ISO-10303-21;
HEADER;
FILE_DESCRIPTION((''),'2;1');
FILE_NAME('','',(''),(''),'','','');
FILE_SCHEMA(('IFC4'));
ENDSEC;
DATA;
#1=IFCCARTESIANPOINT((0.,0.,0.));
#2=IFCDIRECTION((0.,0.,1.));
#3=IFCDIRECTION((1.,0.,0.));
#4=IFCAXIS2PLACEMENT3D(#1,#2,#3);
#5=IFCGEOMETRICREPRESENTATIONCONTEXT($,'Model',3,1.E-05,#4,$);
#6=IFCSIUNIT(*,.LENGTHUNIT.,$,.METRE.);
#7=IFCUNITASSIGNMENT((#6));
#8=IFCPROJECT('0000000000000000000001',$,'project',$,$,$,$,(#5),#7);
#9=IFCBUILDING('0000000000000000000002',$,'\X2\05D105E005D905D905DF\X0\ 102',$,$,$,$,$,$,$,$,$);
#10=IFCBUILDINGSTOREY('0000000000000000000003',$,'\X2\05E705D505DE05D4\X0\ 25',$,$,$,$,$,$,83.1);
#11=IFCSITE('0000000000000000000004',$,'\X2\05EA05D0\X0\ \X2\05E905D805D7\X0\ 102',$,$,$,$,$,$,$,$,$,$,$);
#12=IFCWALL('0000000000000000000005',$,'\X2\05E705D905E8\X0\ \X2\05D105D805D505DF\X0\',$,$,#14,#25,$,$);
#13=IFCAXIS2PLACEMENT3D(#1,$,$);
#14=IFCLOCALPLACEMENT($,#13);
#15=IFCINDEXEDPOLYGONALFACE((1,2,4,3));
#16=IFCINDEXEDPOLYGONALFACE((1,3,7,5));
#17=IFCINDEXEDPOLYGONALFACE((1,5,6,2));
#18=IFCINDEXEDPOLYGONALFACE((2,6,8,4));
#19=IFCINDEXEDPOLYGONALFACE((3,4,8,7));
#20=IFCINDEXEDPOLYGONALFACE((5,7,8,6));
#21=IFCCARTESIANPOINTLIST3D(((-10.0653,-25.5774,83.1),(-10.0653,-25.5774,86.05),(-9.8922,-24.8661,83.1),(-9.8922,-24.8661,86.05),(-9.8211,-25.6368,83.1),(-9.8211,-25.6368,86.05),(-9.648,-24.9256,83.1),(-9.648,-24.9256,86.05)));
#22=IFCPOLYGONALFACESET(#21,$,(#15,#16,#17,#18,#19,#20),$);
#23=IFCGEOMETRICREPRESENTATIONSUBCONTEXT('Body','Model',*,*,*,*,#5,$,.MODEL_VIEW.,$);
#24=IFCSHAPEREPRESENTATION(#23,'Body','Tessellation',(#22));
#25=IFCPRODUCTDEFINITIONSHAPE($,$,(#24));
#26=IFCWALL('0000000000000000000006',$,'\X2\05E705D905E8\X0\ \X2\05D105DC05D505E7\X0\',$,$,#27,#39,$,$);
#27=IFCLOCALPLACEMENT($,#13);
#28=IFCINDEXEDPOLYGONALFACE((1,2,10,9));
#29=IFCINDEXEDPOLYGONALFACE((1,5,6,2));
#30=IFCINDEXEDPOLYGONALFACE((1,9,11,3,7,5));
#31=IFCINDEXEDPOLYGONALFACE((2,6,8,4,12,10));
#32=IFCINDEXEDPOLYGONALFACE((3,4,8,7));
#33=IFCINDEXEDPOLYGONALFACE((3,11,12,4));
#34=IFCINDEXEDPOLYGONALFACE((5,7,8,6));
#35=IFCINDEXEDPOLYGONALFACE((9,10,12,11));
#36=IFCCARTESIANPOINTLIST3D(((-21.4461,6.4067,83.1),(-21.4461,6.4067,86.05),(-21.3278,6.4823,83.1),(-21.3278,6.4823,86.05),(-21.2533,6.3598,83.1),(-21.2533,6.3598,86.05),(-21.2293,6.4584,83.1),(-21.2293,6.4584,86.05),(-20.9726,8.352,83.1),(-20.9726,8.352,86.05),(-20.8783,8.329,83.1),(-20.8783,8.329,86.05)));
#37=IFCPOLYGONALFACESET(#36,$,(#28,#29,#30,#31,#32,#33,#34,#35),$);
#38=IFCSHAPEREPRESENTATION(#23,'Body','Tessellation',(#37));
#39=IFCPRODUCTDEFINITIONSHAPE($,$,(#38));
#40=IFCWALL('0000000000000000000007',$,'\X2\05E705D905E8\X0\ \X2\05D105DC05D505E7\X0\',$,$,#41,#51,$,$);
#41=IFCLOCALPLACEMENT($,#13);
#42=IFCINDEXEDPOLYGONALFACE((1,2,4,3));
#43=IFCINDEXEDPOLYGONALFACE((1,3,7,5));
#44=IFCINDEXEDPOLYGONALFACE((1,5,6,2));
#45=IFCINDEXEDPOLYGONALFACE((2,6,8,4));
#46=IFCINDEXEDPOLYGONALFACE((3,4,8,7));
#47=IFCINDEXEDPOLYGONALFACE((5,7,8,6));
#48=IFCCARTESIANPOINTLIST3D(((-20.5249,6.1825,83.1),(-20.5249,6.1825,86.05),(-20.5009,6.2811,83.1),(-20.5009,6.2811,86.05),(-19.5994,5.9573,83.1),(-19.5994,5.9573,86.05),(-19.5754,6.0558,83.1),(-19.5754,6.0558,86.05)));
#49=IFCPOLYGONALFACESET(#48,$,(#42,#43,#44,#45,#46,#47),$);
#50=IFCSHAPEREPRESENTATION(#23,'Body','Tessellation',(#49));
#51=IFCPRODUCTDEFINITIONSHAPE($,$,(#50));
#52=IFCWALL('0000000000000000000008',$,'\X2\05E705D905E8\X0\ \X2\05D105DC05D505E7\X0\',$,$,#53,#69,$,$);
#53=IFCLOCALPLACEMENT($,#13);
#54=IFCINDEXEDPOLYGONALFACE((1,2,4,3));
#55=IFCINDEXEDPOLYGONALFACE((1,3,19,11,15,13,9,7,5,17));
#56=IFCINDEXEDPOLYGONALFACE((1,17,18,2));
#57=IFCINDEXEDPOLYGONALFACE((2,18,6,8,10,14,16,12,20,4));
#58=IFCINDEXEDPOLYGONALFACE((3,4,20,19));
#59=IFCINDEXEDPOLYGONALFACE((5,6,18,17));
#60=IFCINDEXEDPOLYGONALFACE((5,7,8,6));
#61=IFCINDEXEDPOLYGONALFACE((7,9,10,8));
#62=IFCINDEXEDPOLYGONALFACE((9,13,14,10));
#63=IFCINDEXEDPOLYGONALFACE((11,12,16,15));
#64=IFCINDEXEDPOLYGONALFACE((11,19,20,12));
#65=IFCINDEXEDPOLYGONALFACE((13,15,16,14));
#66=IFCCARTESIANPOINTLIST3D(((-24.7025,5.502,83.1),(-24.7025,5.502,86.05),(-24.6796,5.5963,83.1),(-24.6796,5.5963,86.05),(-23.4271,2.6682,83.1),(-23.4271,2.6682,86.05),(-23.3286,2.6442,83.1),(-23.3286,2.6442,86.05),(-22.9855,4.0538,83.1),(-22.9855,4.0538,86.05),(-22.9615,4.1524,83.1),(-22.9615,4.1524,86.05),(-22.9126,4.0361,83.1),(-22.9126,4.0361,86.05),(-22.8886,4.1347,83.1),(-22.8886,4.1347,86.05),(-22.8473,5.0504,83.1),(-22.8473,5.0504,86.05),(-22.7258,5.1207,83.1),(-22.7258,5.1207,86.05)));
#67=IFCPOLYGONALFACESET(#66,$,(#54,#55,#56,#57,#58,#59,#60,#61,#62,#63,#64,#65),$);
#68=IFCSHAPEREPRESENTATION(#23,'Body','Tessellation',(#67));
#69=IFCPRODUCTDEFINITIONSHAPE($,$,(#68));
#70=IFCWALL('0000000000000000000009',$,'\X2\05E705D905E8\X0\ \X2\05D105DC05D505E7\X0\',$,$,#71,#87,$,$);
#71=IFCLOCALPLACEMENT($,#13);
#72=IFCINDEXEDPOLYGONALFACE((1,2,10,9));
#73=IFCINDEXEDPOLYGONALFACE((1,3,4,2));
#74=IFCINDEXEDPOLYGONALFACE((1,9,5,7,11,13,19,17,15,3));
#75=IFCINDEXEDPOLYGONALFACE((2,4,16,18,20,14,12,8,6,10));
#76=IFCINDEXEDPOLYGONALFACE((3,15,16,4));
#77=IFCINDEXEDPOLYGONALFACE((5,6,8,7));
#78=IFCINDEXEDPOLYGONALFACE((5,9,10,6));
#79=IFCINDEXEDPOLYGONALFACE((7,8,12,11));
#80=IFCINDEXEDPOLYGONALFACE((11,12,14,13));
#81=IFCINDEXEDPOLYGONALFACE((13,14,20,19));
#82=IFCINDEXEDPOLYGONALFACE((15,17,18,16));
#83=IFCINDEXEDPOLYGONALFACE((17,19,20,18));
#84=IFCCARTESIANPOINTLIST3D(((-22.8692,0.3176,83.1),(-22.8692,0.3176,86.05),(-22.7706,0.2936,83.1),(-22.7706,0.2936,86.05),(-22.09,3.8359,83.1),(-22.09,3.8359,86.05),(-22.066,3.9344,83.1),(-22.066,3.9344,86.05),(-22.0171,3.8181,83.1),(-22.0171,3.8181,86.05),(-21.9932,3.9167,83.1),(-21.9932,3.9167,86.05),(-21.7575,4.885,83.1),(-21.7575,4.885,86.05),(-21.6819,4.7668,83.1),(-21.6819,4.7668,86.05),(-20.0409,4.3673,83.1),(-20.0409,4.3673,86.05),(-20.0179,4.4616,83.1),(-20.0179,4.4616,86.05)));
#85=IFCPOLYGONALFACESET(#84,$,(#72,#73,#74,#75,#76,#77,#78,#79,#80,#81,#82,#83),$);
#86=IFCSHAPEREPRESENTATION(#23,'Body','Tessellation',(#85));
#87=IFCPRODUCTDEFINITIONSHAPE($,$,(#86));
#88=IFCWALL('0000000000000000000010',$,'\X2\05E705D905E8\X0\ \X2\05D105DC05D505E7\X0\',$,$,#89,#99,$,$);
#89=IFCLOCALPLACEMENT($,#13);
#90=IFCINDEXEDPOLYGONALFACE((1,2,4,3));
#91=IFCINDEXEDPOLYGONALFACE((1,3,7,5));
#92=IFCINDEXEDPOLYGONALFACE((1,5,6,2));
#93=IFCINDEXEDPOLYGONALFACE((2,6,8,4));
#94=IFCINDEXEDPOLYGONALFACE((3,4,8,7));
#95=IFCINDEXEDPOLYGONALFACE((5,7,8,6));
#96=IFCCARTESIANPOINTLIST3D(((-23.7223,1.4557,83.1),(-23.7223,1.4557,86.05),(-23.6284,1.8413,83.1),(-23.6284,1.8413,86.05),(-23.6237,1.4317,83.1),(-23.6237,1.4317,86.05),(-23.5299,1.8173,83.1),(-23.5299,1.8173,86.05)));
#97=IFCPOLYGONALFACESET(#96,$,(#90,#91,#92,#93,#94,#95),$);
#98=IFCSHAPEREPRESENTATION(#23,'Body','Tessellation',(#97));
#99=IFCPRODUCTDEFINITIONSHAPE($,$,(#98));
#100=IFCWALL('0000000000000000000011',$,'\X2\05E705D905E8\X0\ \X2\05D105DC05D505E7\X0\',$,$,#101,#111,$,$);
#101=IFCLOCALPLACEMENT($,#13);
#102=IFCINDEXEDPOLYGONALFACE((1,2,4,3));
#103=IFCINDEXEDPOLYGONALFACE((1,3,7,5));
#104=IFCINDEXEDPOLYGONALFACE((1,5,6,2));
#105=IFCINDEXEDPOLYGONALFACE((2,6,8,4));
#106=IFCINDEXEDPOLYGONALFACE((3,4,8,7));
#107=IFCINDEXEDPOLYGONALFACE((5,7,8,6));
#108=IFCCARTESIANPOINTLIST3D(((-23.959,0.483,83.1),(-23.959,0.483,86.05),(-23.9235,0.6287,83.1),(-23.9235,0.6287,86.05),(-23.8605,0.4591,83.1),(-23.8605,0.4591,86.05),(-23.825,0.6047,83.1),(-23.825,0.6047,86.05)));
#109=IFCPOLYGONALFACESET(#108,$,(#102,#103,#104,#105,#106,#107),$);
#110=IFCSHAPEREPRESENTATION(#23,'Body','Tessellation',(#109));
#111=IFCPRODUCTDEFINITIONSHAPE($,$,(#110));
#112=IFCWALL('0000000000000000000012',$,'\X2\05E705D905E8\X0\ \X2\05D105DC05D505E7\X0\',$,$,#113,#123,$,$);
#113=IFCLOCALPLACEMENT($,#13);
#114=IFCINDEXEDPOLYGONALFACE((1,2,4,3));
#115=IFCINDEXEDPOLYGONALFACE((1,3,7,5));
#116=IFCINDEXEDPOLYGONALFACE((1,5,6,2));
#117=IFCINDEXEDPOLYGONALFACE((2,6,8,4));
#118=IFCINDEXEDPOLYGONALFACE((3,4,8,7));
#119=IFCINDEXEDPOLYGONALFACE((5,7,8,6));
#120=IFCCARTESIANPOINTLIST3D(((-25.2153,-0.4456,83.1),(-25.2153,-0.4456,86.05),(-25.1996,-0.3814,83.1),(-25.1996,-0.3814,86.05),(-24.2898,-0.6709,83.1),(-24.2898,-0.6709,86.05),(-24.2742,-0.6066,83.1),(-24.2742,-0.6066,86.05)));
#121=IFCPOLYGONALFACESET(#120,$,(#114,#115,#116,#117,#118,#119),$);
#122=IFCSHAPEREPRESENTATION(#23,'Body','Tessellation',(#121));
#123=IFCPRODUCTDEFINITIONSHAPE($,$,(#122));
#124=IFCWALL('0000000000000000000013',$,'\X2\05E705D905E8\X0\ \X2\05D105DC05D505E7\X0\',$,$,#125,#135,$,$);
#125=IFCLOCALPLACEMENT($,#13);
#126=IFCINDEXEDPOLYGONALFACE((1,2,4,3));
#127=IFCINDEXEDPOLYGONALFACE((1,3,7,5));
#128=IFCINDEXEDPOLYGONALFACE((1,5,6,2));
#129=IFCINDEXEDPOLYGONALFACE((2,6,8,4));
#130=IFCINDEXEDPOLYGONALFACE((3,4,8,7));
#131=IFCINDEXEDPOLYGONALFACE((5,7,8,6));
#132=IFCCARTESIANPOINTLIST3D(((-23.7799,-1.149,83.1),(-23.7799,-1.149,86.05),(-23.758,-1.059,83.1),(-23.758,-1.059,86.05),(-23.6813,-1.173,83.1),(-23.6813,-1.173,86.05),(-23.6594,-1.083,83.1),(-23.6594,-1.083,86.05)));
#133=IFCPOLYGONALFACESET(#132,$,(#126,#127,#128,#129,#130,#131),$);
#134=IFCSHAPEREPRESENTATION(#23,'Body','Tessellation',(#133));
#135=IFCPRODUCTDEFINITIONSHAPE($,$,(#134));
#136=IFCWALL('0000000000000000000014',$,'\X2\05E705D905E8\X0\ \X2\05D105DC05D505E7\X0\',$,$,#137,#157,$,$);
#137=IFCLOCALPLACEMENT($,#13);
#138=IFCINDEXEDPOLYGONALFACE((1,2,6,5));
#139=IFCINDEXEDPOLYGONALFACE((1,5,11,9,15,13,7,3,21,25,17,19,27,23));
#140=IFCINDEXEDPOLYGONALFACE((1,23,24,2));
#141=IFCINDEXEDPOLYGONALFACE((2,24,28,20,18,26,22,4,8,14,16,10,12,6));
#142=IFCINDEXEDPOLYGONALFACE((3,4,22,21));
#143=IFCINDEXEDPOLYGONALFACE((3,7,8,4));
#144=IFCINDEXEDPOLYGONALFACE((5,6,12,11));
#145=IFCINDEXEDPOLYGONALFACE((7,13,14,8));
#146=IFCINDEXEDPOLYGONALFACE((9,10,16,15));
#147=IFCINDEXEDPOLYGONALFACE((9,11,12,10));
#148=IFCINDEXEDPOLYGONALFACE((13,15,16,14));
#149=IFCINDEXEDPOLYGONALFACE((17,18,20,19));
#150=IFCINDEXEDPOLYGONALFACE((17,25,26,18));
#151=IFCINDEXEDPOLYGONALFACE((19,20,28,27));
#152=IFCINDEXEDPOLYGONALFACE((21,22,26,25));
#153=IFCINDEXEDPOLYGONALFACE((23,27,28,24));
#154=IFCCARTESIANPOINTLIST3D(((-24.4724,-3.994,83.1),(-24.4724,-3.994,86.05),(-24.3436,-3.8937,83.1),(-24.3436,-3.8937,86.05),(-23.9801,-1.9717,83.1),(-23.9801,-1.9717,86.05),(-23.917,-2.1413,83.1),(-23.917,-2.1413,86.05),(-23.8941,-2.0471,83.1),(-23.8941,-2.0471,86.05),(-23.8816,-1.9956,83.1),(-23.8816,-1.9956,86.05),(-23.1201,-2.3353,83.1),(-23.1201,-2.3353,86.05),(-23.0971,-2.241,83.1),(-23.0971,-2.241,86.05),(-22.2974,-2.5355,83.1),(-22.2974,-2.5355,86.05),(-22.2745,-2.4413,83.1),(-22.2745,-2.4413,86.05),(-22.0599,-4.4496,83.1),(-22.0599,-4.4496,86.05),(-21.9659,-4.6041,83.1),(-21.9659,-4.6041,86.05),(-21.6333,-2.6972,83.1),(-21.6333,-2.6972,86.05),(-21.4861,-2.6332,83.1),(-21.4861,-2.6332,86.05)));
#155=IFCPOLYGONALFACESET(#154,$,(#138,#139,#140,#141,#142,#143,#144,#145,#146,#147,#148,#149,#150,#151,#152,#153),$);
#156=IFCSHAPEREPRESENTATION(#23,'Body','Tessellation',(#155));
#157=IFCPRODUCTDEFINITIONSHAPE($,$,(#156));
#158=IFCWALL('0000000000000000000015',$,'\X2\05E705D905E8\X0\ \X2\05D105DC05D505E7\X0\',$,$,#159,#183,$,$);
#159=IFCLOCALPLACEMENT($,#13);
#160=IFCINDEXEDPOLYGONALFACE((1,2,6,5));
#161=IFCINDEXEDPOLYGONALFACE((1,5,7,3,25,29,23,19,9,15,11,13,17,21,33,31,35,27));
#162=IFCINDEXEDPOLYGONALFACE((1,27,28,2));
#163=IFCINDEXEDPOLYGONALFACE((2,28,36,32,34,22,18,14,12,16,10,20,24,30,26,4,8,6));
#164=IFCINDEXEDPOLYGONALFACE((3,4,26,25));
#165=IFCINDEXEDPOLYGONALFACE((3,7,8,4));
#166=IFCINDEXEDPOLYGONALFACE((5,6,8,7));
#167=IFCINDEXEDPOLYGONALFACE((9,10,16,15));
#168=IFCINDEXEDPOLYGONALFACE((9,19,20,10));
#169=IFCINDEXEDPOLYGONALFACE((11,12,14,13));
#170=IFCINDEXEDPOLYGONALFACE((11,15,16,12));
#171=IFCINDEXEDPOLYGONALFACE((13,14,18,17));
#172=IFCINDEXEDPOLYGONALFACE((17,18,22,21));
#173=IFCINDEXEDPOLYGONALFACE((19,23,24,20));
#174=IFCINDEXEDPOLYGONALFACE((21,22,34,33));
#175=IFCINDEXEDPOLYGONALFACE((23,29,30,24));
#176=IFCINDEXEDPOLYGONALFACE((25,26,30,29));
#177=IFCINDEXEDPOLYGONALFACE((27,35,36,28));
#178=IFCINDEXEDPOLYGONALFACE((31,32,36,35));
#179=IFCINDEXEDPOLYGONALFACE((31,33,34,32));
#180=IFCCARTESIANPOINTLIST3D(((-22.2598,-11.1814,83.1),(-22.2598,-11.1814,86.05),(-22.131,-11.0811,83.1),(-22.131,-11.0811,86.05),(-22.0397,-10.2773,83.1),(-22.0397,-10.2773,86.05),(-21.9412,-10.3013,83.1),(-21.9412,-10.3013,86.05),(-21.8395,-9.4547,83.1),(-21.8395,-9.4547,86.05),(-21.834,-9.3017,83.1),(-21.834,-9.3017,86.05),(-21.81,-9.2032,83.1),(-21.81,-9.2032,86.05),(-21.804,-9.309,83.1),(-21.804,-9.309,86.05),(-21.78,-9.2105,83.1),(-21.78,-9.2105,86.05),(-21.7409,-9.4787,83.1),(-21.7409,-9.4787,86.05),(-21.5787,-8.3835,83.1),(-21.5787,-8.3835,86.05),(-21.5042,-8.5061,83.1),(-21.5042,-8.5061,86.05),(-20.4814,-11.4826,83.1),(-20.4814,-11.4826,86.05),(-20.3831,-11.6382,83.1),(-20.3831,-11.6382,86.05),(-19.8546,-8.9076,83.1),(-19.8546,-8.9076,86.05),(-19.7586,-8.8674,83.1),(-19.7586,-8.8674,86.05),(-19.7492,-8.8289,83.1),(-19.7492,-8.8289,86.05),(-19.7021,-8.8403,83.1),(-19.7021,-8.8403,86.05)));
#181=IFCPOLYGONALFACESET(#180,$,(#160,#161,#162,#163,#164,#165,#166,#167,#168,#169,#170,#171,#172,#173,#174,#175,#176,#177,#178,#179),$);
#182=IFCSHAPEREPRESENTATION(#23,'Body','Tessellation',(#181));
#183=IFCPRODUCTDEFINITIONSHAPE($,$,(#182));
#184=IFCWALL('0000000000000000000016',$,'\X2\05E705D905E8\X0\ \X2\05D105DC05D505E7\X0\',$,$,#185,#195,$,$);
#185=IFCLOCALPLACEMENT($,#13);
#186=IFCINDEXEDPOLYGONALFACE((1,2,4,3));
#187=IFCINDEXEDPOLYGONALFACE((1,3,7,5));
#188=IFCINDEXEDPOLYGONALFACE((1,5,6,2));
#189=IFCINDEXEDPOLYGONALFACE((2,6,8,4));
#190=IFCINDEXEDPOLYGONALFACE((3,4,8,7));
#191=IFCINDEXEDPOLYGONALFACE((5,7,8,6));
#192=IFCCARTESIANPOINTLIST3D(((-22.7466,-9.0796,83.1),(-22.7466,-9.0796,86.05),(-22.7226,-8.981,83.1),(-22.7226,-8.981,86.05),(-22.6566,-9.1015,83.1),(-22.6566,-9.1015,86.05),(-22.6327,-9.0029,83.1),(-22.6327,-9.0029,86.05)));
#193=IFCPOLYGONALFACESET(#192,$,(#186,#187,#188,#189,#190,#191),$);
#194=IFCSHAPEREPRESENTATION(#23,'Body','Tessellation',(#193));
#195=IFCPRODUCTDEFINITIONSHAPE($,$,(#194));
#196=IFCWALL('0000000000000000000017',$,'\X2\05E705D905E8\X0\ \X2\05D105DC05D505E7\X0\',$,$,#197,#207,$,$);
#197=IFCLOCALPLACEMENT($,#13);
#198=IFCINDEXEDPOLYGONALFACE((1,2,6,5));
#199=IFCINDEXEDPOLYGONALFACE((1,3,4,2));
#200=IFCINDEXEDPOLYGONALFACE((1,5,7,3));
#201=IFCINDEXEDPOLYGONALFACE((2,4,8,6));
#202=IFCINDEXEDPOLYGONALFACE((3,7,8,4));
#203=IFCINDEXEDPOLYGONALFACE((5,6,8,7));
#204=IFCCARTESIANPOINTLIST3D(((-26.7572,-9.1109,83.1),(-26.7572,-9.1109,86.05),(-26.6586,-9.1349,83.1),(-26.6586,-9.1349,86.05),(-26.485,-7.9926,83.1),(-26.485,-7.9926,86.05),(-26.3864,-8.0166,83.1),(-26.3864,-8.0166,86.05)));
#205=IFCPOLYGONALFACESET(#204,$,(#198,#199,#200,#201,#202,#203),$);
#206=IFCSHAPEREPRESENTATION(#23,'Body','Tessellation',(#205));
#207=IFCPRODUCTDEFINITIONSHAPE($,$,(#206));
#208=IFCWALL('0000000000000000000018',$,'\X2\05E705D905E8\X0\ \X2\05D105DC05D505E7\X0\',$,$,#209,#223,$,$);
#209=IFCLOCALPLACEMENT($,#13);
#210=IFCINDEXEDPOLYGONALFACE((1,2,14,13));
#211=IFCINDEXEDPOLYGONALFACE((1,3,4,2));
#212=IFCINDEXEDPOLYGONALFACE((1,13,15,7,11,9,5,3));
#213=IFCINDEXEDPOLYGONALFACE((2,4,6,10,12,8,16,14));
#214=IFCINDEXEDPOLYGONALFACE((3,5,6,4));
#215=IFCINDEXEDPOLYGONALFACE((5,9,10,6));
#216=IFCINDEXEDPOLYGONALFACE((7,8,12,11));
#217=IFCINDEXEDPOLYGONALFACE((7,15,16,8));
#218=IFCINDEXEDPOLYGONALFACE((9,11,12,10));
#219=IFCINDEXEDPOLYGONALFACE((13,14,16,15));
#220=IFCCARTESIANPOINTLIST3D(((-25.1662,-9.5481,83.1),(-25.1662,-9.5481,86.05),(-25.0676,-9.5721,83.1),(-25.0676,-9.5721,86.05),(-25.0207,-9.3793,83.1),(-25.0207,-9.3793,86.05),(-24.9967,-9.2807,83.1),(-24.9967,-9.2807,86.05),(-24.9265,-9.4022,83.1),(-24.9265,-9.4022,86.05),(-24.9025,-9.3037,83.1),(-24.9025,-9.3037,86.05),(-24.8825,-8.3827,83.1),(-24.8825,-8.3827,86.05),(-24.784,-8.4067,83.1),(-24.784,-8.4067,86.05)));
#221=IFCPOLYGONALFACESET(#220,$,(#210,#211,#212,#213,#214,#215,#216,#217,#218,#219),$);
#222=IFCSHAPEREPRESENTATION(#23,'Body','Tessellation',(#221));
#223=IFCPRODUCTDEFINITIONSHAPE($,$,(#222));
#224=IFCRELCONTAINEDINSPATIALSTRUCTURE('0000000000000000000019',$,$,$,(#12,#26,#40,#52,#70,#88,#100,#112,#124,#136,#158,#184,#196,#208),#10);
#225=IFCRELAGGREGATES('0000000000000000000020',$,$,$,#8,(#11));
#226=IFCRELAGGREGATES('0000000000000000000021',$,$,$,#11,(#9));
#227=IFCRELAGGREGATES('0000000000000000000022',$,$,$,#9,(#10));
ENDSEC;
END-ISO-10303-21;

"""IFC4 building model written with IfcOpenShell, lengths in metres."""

from ifc_helpers import new_model, si_unit, frame, origin_with_axes, context, subcontext, project, spatial, polyline, outline, extrude, element, save


model = new_model("IFC4")

# Units and contexts
model_context = context("Model", 3, precision=1e-05, world=origin_with_axes())
body_context = subcontext(model_context, "Body", "Model", "MODEL_VIEW")
ifc_project = project(units=[si_unit("LENGTHUNIT", "METRE")], contexts=[model_context])

# Site, building, storey
site = spatial("IfcSite", under=ifc_project, Name="תא שטח 102")
building = spatial("IfcBuilding", under=site, Name="בניין 102")
storey = spatial("IfcBuildingStorey", under=building, Name="קומה 25", Elevation=83.1)

# Walls
element("IfcWall", 1, inside=storey, Name="קיר בטון", context=body_context, shape_type="SweptSolid", body=[
    extrude(outline(polyline([(-10.0653, -25.5774), (-9.8211, -25.6368), (-9.648, -24.9256), (-9.8922, -24.8661), (-10.0653, -25.5774)])), frame((0.0, 0.0, 83.1)), (0.0, 0.0, 1.0), 2.95),
])
element("IfcWall", 2, inside=storey, Name="קיר בלוק", context=body_context, shape_type="SweptSolid", body=[
    extrude(outline(polyline([(-21.4461, 6.4067), (-21.2533, 6.3598), (-21.2293, 6.4584), (-21.3278, 6.4823), (-20.8783, 8.329), (-20.9726, 8.352), (-21.4461, 6.4067)])), frame((0.0, 0.0, 83.1)), (0.0, 0.0, 1.0), 2.95),
])
element("IfcWall", 3, inside=storey, Name="קיר בלוק", context=body_context, shape_type="SweptSolid", body=[
    extrude(outline(polyline([(-19.5754, 6.0558), (-20.5009, 6.2811), (-20.5249, 6.1825), (-19.5994, 5.9573), (-19.5754, 6.0558)])), frame((0.0, 0.0, 83.1)), (0.0, 0.0, 1.0), 2.95),
])
element("IfcWall", 4, inside=storey, Name="קיר בלוק", context=body_context, shape_type="SweptSolid", body=[
    extrude(outline(polyline([(-23.4271, 2.6682), (-23.3286, 2.6442), (-22.9855, 4.0538), (-22.9126, 4.0361), (-22.8886, 4.1347), (-22.9615, 4.1524), (-22.7258, 5.1207), (-24.6796, 5.5963), (-24.7025, 5.502), (-22.8473, 5.0504), (-23.4271, 2.6682)])), frame((0.0, 0.0, 83.1)), (0.0, 0.0, 1.0), 2.95),
])
element("IfcWall", 5, inside=storey, Name="קיר בלוק", context=body_context, shape_type="SweptSolid", body=[
    extrude(outline(polyline([(-22.09, 3.8359), (-22.0171, 3.8181), (-22.8692, 0.3176), (-22.7706, 0.2936), (-21.6819, 4.7668), (-20.0409, 4.3673), (-20.0179, 4.4616), (-21.7575, 4.885), (-21.9932, 3.9167), (-22.066, 3.9344), (-22.09, 3.8359)])), frame((0.0, 0.0, 83.1)), (0.0, 0.0, 1.0), 2.95),
])
element("IfcWall", 6, inside=storey, Name="קיר בלוק", context=body_context, shape_type="SweptSolid", body=[
    extrude(outline(polyline([(-23.5299, 1.8173), (-23.6284, 1.8413), (-23.7223, 1.4557), (-23.6237, 1.4317), (-23.5299, 1.8173)])), frame((0.0, 0.0, 83.1)), (0.0, 0.0, 1.0), 2.95),
])
element("IfcWall", 7, inside=storey, Name="קיר בלוק", context=body_context, shape_type="SweptSolid", body=[
    extrude(outline(polyline([(-23.9235, 0.6287), (-23.959, 0.483), (-23.8605, 0.4591), (-23.825, 0.6047), (-23.9235, 0.6287)])), frame((0.0, 0.0, 83.1)), (0.0, 0.0, 1.0), 2.95),
])
element("IfcWall", 8, inside=storey, Name="קיר בלוק", context=body_context, shape_type="SweptSolid", body=[
    extrude(outline(polyline([(-25.1996, -0.3814), (-25.2153, -0.4456), (-24.2898, -0.6709), (-24.2742, -0.6066), (-25.1996, -0.3814)])), frame((0.0, 0.0, 83.1)), (0.0, 0.0, 1.0), 2.95),
])
element("IfcWall", 9, inside=storey, Name="קיר בלוק", context=body_context, shape_type="SweptSolid", body=[
    extrude(outline(polyline([(-23.6594, -1.083), (-23.758, -1.059), (-23.7799, -1.149), (-23.6813, -1.173), (-23.6594, -1.083)])), frame((0.0, 0.0, 83.1)), (0.0, 0.0, 1.0), 2.95),
])
element("IfcWall", 10, inside=storey, Name="קיר בלוק", context=body_context, shape_type="SweptSolid", body=[
    extrude(outline(polyline([(-24.3436, -3.8937), (-23.917, -2.1413), (-23.1201, -2.3353), (-23.0971, -2.241), (-23.8941, -2.0471), (-23.8816, -1.9956), (-23.9801, -1.9717), (-24.4724, -3.994), (-21.9659, -4.6041), (-21.4861, -2.6332), (-22.2745, -2.4413), (-22.2974, -2.5355), (-21.6333, -2.6972), (-22.0599, -4.4496), (-24.3436, -3.8937)])), frame((0.0, 0.0, 83.1)), (0.0, 0.0, 1.0), 2.95),
])
element("IfcWall", 11, inside=storey, Name="קיר בלוק", context=body_context, shape_type="SweptSolid", body=[
    extrude(outline(polyline([(-21.81, -9.2032), (-21.834, -9.3017), (-21.804, -9.309), (-21.8395, -9.4547), (-21.7409, -9.4787), (-21.5042, -8.5061), (-19.8546, -8.9076), (-20.4814, -11.4826), (-22.131, -11.0811), (-21.9412, -10.3013), (-22.0397, -10.2773), (-22.2598, -11.1814), (-20.3831, -11.6382), (-19.7021, -8.8403), (-19.7586, -8.8674), (-19.7492, -8.8289), (-21.5787, -8.3835), (-21.78, -9.2105), (-21.81, -9.2032)])), frame((0.0, 0.0, 83.1)), (0.0, 0.0, 1.0), 2.95),
])
element("IfcWall", 12, inside=storey, Name="קיר בלוק", context=body_context, shape_type="SweptSolid", body=[
    extrude(outline(polyline([(-22.7226, -8.981), (-22.7466, -9.0796), (-22.6566, -9.1015), (-22.6327, -9.0029), (-22.7226, -8.981)])), frame((0.0, 0.0, 83.1)), (0.0, 0.0, 1.0), 2.95),
])
element("IfcWall", 13, inside=storey, Name="קיר בלוק", context=body_context, shape_type="SweptSolid", body=[
    extrude(outline(polyline([(-26.7572, -9.1109), (-26.6586, -9.1349), (-26.3864, -8.0166), (-26.485, -7.9926), (-26.7572, -9.1109)])), frame((0.0, 0.0, 83.1)), (0.0, 0.0, 1.0), 2.95),
])
element("IfcWall", 14, inside=storey, Name="קיר בלוק", context=body_context, shape_type="SweptSolid", body=[
    extrude(outline(polyline([(-24.9025, -9.3037), (-24.9967, -9.2807), (-24.784, -8.4067), (-24.8825, -8.3827), (-25.1662, -9.5481), (-25.0676, -9.5721), (-25.0207, -9.3793), (-24.9265, -9.4022), (-24.9025, -9.3037)])), frame((0.0, 0.0, 83.1)), (0.0, 0.0, 1.0), 2.95),
])

save(model, "model.ifc")
